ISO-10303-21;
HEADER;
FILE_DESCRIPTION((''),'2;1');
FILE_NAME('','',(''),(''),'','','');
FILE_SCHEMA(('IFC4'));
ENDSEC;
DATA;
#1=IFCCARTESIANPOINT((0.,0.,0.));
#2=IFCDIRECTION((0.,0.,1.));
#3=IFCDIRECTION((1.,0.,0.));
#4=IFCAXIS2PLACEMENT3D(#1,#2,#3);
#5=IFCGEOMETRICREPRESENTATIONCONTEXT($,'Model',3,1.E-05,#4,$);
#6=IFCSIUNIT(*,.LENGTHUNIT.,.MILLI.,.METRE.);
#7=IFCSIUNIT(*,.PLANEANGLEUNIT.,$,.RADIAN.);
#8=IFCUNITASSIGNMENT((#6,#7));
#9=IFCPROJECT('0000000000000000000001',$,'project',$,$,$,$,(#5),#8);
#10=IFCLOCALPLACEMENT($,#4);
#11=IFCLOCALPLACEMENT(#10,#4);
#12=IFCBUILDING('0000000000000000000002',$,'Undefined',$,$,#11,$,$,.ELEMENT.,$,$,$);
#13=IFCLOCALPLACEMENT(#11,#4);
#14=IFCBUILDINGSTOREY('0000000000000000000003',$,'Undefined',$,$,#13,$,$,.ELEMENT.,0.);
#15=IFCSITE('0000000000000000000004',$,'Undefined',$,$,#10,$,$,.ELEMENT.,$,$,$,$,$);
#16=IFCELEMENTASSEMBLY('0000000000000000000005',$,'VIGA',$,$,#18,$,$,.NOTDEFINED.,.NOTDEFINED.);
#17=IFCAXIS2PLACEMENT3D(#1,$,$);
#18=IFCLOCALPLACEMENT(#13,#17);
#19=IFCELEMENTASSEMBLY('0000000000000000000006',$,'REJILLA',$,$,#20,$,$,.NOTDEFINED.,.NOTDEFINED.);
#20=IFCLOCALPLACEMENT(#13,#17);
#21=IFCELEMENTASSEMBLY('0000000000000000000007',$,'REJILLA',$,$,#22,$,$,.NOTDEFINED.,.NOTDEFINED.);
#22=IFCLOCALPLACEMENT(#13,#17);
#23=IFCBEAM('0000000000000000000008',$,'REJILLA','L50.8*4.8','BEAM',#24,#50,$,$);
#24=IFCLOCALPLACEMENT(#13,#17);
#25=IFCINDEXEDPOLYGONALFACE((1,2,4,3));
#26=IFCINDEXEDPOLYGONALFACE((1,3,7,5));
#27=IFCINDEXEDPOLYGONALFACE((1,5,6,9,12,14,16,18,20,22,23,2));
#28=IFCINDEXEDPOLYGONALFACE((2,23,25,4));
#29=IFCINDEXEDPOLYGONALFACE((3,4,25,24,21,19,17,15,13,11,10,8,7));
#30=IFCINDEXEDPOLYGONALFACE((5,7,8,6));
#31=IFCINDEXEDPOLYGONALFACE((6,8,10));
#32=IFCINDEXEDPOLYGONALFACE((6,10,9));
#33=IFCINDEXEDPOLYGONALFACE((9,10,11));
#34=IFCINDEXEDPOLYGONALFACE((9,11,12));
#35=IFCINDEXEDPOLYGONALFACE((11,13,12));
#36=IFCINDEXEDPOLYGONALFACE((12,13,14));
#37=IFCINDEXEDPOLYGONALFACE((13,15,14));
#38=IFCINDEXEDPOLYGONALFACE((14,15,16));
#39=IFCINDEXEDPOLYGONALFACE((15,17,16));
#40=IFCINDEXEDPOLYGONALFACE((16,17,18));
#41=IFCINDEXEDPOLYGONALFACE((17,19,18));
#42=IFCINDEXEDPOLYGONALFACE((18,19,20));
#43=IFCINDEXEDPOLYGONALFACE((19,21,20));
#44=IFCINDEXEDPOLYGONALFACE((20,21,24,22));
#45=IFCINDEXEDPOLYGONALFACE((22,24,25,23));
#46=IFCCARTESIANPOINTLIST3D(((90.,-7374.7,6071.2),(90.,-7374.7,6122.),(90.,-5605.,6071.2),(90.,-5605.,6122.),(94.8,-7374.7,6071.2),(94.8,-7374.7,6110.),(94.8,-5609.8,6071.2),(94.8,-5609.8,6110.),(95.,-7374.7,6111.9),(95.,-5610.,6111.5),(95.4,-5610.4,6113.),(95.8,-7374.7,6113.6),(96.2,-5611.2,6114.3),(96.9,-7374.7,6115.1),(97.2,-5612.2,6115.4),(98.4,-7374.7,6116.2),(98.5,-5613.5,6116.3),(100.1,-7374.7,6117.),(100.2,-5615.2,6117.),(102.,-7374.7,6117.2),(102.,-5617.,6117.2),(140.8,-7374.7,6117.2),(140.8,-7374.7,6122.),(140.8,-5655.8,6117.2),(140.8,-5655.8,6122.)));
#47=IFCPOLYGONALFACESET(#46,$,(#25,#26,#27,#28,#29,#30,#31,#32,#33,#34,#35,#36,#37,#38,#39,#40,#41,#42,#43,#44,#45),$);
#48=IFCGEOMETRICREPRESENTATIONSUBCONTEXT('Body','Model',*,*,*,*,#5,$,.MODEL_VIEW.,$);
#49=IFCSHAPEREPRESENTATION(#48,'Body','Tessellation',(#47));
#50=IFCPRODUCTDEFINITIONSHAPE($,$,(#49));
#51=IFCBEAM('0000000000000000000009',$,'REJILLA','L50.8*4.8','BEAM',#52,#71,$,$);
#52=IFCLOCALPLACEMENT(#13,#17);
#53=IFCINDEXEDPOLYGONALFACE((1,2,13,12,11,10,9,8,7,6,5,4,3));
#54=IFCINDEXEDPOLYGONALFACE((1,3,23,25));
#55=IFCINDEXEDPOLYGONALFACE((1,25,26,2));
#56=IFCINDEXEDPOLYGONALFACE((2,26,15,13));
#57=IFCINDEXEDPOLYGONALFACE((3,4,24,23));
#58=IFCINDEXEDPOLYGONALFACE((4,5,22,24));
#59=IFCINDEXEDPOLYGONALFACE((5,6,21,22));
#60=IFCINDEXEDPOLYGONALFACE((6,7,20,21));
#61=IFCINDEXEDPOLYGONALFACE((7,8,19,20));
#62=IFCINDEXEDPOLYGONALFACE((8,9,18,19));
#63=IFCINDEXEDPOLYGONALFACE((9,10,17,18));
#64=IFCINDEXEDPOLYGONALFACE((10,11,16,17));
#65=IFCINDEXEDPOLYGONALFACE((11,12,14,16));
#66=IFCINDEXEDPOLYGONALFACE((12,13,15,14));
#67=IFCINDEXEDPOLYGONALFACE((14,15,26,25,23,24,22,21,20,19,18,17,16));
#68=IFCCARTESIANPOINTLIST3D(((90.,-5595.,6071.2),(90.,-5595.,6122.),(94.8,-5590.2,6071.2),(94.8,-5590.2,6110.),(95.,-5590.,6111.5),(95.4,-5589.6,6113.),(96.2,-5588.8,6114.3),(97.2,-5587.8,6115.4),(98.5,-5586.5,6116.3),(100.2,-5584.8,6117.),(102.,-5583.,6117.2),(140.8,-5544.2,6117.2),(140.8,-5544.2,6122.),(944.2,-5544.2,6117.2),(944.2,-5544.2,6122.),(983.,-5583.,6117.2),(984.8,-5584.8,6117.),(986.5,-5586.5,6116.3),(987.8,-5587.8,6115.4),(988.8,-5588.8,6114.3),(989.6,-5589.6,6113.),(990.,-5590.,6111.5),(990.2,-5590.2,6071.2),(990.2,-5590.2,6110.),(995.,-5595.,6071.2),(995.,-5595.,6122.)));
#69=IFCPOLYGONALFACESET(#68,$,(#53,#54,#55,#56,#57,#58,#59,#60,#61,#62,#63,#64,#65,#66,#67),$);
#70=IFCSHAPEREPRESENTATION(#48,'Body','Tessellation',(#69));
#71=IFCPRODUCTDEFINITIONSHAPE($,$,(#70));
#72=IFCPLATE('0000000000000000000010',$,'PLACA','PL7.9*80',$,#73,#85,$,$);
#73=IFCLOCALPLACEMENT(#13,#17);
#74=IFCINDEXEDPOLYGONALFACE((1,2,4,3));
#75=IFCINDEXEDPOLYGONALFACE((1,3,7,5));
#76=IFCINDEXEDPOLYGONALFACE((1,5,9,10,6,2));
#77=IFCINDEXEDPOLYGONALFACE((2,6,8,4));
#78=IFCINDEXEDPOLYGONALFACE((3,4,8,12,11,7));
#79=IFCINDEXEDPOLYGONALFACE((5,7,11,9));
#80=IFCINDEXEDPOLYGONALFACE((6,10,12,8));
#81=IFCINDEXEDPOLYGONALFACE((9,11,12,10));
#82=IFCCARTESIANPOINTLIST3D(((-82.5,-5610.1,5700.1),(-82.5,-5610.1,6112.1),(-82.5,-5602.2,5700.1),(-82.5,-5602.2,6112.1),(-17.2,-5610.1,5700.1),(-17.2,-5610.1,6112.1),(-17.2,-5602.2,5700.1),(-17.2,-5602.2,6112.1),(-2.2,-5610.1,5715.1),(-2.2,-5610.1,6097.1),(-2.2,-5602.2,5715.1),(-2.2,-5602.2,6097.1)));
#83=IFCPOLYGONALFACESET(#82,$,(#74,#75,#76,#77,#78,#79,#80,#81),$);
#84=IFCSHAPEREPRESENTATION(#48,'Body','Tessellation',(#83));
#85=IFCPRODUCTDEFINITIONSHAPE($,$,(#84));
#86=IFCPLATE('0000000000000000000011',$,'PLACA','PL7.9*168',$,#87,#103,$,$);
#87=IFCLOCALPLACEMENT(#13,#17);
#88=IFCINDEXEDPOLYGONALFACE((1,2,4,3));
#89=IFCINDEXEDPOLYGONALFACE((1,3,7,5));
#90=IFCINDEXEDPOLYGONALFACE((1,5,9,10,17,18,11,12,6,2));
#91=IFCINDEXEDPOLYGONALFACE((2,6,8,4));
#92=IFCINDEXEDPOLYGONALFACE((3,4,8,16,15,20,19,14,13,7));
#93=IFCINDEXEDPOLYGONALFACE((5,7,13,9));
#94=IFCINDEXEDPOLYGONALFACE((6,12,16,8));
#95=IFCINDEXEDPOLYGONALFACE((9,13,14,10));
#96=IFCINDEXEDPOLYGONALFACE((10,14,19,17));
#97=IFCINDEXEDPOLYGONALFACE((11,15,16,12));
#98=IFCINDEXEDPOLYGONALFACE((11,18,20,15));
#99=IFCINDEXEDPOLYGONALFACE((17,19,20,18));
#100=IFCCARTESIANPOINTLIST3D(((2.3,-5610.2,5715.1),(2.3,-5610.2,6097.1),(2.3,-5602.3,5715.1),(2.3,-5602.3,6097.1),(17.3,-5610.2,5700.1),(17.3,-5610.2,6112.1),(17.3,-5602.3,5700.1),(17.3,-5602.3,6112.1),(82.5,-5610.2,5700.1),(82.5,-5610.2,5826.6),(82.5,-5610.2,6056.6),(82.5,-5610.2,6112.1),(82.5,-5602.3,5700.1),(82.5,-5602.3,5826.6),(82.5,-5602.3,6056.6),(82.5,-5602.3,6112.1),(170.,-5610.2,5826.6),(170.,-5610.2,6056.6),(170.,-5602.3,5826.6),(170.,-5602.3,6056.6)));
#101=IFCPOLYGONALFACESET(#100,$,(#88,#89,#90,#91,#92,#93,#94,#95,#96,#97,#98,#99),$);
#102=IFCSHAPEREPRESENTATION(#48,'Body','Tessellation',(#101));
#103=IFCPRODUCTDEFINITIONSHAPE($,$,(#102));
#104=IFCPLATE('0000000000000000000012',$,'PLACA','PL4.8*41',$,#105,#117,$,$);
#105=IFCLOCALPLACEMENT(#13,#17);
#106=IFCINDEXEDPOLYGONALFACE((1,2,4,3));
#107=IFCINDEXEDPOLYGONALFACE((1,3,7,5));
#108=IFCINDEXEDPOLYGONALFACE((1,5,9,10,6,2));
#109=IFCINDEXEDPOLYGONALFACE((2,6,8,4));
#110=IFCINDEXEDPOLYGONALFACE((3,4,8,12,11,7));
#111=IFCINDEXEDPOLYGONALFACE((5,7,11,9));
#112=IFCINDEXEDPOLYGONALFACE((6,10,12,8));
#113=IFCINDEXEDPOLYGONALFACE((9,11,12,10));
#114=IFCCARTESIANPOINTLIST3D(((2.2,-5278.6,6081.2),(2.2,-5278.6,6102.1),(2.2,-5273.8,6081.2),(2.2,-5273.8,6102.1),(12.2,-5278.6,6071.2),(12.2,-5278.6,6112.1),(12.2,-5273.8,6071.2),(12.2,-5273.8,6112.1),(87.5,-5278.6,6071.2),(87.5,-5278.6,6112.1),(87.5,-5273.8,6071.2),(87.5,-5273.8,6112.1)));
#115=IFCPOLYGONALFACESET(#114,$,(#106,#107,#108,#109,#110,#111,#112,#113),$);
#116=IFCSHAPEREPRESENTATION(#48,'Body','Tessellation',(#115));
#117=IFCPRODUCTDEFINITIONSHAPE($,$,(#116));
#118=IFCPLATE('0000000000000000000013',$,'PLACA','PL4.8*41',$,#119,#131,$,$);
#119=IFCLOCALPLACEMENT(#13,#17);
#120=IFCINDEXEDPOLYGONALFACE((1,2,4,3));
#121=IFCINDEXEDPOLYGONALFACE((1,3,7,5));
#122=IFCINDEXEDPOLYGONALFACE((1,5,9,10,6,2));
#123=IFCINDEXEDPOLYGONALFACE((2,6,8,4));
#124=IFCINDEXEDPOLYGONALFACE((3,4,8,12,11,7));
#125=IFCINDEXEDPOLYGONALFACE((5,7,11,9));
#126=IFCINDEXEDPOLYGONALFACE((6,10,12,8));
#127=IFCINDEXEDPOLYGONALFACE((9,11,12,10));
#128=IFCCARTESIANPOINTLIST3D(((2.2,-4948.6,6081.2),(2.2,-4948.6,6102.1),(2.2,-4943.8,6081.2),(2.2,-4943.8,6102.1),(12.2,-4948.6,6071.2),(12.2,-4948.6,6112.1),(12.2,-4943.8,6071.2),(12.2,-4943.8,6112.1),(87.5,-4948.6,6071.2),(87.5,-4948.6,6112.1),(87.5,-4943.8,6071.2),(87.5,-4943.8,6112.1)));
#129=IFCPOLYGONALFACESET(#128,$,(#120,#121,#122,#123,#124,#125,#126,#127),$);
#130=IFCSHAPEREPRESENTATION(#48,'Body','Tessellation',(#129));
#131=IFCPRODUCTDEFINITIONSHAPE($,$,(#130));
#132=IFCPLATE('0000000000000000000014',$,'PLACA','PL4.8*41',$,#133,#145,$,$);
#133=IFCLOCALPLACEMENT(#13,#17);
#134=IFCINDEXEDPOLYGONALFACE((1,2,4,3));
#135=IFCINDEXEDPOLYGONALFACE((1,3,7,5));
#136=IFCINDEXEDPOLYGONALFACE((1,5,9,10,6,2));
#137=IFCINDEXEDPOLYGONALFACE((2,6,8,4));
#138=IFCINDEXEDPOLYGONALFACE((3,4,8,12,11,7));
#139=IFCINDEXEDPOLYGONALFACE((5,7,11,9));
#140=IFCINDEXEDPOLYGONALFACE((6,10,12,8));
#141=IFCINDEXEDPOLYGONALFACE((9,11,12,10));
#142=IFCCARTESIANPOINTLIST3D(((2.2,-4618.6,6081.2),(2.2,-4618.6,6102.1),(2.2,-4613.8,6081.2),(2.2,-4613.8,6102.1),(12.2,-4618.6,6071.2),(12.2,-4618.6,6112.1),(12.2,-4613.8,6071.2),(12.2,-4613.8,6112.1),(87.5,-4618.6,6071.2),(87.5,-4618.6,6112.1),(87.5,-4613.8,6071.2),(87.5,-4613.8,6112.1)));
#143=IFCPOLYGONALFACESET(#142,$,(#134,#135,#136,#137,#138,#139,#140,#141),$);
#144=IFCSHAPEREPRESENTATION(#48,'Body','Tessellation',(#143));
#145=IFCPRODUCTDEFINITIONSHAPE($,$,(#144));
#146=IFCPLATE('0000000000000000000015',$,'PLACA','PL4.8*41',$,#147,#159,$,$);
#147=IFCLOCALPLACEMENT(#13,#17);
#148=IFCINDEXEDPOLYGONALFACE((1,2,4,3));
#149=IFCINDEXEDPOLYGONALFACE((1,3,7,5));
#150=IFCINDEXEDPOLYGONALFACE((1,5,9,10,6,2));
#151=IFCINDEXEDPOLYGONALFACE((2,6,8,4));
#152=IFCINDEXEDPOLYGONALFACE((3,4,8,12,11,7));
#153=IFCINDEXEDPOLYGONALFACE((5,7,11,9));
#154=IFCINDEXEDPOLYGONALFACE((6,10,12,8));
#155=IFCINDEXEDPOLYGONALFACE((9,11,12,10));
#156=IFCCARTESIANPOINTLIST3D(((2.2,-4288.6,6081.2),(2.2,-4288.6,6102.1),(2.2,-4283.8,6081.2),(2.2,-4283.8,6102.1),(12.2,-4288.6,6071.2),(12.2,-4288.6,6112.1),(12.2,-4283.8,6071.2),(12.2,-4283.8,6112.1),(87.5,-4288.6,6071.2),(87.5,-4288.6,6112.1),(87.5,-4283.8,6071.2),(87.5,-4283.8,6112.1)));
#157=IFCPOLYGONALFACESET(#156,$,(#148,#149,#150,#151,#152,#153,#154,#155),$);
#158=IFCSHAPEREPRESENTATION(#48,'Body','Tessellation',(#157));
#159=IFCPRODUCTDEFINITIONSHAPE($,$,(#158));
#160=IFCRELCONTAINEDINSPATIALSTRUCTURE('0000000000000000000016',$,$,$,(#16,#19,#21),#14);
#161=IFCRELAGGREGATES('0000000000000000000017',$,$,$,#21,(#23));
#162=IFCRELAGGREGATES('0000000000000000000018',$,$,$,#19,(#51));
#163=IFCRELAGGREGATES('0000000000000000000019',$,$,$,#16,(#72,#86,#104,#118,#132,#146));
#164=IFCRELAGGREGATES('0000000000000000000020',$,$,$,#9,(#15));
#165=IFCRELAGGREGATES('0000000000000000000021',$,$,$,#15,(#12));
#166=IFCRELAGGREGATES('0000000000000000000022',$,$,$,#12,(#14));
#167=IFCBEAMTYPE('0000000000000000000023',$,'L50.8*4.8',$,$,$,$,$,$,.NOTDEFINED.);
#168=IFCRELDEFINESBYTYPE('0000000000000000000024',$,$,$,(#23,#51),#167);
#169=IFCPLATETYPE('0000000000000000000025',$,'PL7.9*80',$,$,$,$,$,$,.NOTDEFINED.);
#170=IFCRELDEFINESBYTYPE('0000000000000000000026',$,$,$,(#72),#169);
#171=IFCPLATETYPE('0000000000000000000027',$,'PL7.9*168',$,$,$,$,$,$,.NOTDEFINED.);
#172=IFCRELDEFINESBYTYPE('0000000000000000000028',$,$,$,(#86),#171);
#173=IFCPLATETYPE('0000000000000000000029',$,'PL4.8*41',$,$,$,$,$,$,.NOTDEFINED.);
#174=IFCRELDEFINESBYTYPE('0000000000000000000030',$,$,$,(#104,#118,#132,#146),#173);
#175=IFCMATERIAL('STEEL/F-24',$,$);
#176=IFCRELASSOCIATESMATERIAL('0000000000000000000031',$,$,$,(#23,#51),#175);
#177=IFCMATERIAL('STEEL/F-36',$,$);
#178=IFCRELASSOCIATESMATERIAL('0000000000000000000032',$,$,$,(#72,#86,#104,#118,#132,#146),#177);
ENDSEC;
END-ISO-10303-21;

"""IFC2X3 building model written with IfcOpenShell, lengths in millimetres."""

from ifc_helpers import new_model, si_unit, frame, origin_with_axes, origin_2d_with_axis, place, context, subcontext, project, spatial, polyline, l_section, outline, extrude, clip, halfspace, material, type_object, element, aggregate, save


model = new_model("IFC2X3")

# Units and contexts
model_context = context("Model", 3, precision=1e-05, world=origin_with_axes())
body_context = subcontext(model_context, "Body", "Model", "MODEL_VIEW")
ifc_project = project(units=[si_unit("LENGTHUNIT", "METRE", prefix="MILLI"), si_unit("PLANEANGLEUNIT", "RADIAN")], contexts=[model_context])

# Site, building, storey
site_placement = place(None, origin_with_axes())
site = spatial("IfcSite", under=ifc_project, at=site_placement, Name="Undefined", CompositionType="ELEMENT")
building_placement = place(site_placement, origin_with_axes())
building = spatial("IfcBuilding", under=site, at=building_placement, Name="Undefined", CompositionType="ELEMENT")
storey_placement = place(building_placement, origin_with_axes())
storey = spatial("IfcBuildingStorey", under=building, at=storey_placement, Name="Undefined", CompositionType="ELEMENT", Elevation=0.0)

# Element assembly
assembly_1_placement = place(storey_placement, origin_with_axes())
assembly_1 = element("IfcElementAssembly", 1, at=assembly_1_placement, inside=storey, Name="VIGA", AssemblyPlace="NOTDEFINED", PredefinedType="NOTDEFINED")
ifc_material_1 = material(Name="STEEL/F-24")

# Element assemblies, beam
assembly_2_placement = place(storey_placement, origin_with_axes())
assembly_2 = element("IfcElementAssembly", 2, at=assembly_2_placement, inside=storey, Name="REJILLA", AssemblyPlace="NOTDEFINED", PredefinedType="NOTDEFINED")
assembly_3_placement = place(storey_placement, origin_with_axes())
assembly_3 = element("IfcElementAssembly", 3, at=assembly_3_placement, inside=storey, Name="REJILLA", AssemblyPlace="NOTDEFINED", PredefinedType="NOTDEFINED")
beam_type_1 = type_object("IfcBeamType", Name="L50.8*4.8", PredefinedType="NOTDEFINED")
beam_1_placement = place(assembly_3_placement, frame((115.4, -5605.0, 6096.6), z_axis=(0.0, 0.0, -1.0), x_axis=(0.0, -1.0, 0.0)))
beam_1 = element("IfcBeam", 4, at=beam_1_placement, type_object=beam_type_1, material=ifc_material_1, Name="REJILLA", Description="L50.8*4.8", ObjectType="BEAM", context=body_context, shape_type="Clipping", body=[
    clip(extrude(l_section(Depth=50.8, Width=50.8, Thickness=4.8, FilletRadius=7.2, at=origin_2d_with_axis()), frame((1769.7, 0.0, 0.0), z_axis=(-1.0, 0.0, 0.0), x_axis=(0.0, -1.0, 0.0)), (0.0, 0.0, 1.0), 1800.5), halfspace(frame((50.8, -25.4, 0.0), z_axis=(-0.707107, -0.707107, 0.0), x_axis=(0.0, 0.0, -1.0)), False)),
])
aggregate(assembly_3, [beam_1])

# Beam
beam_2_placement = place(assembly_2_placement, frame((90.0, -5569.6, 6096.6), z_axis=(0.0, 0.0, -1.0), x_axis=(1.0, 0.0, 0.0)))
beam_2 = element("IfcBeam", 5, at=beam_2_placement, type_object=beam_type_1, material=ifc_material_1, Name="REJILLA", Description="L50.8*4.8", ObjectType="BEAM", context=body_context, shape_type="Clipping", body=[
    clip(clip(extrude(l_section(Depth=50.8, Width=50.8, Thickness=4.8, FilletRadius=7.2, at=origin_2d_with_axis()), frame((930.9, 0.0, 0.0), z_axis=(-1.0, 0.0, 0.0), x_axis=(0.0, -1.0, 0.0)), (0.0, 0.0, 1.0), 956.8), halfspace(frame((854.2, -25.4, 0.0), z_axis=(-0.707107, 0.707107, 0.0), x_axis=(0.0, 0.0, -1.0)), True)), halfspace(frame((50.8, -25.4, 0.0), z_axis=(-0.707107, -0.707107, 0.0), x_axis=(0.0, 0.0, -1.0)), False)),
])
aggregate(assembly_2, [beam_2])

# Plates
ifc_material_2 = material(Name="STEEL/F-36")
plate_type_1 = type_object("IfcPlateType", Name="PL7.9*80", PredefinedType="NOTDEFINED")
plate_1_placement = place(assembly_1_placement, frame((-2.2, -5606.2, 6112.1), z_axis=(0.0, -1.0, 0.0), x_axis=(-1.0, 0.0, -0.000007)))
plate_1 = element("IfcPlate", 6, at=plate_1_placement, type_object=plate_type_1, material=ifc_material_2, Name="PLACA", Description="PL7.9*80", context=body_context, shape_type="SweptSolid", body=[
    extrude(outline(polyline([(0.0, 15.0), (15.0, 0.0), (80.2, 0.0), (80.3, 412.0), (15.0, 412.0), (0.0, 397.0), (0.0, 15.0)])), frame((0.0, 0.0, -4.0), z_axis=(0.0, 0.0, 1.0), x_axis=(1.0, 0.0, 0.0)), (0.0, 0.0, 1.0), 7.9),
])
plate_type_2 = type_object("IfcPlateType", Name="PL7.9*168", PredefinedType="NOTDEFINED")
plate_2_placement = place(assembly_1_placement, frame((2.3, -5606.2, 6112.1), z_axis=(0.0, 1.0, 0.0), x_axis=(1.0, 0.0, -0.000007)))
plate_2 = element("IfcPlate", 7, at=plate_2_placement, type_object=plate_type_2, material=ifc_material_2, Name="PLACA", Description="PL7.9*168", context=body_context, shape_type="SweptSolid", body=[
    extrude(outline(polyline([(0.0, 15.0), (15.0, 0.0), (80.2, 0.0), (80.3, 55.5), (167.8, 55.5), (167.8, 285.5), (80.3, 285.5), (80.3, 412.0), (15.0, 412.0), (0.0, 397.0), (0.0, 15.0)])), frame((0.0, 0.0, -4.0), z_axis=(0.0, 0.0, 1.0), x_axis=(1.0, 0.0, 0.0)), (0.0, 0.0, 1.0), 7.9),
])
plate_type_3 = type_object("IfcPlateType", Name="PL4.8*41", PredefinedType="NOTDEFINED")
plate_3_placement = place(assembly_1_placement, frame((2.2, -5276.2, 6112.1), z_axis=(0.0, 1.0, 0.0), x_axis=(1.0, 0.0, -0.000007)))
plate_3 = element("IfcPlate", 8, at=plate_3_placement, type_object=plate_type_3, material=ifc_material_2, Name="PLACA", Description="PL4.8*41", context=body_context, shape_type="SweptSolid", body=[
    extrude(outline(polyline([(0.0, 10.0), (10.0, 0.0), (85.2, 0.0), (85.3, 40.9), (10.0, 40.9), (0.0, 30.9), (0.0, 10.0)])), frame((0.0, 0.0, -2.4), z_axis=(0.0, 0.0, 1.0), x_axis=(1.0, 0.0, 0.0)), (0.0, 0.0, 1.0), 4.8),
])
plate_4_placement = place(assembly_1_placement, frame((2.2, -4946.2, 6112.1), z_axis=(0.0, 1.0, 0.0), x_axis=(1.0, 0.0, -0.000007)))
plate_4 = element("IfcPlate", 9, at=plate_4_placement, type_object=plate_type_3, material=ifc_material_2, Name="PLACA", Description="PL4.8*41", context=body_context, shape_type="SweptSolid", body=[
    extrude(outline(polyline([(0.0, 10.0), (10.0, 0.0), (85.2, 0.0), (85.3, 40.9), (10.0, 40.9), (0.0, 30.9), (0.0, 10.0)])), frame((0.0, 0.0, -2.4), z_axis=(0.0, 0.0, 1.0), x_axis=(1.0, 0.0, 0.0)), (0.0, 0.0, 1.0), 4.8),
])
plate_5_placement = place(assembly_1_placement, frame((2.2, -4616.2, 6112.1), z_axis=(0.0, 1.0, 0.0), x_axis=(1.0, 0.0, -0.000007)))
plate_5 = element("IfcPlate", 10, at=plate_5_placement, type_object=plate_type_3, material=ifc_material_2, Name="PLACA", Description="PL4.8*41", context=body_context, shape_type="SweptSolid", body=[
    extrude(outline(polyline([(0.0, 10.0), (10.0, 0.0), (85.2, 0.0), (85.3, 40.9), (10.0, 40.9), (0.0, 30.9), (0.0, 10.0)])), frame((0.0, 0.0, -2.4), z_axis=(0.0, 0.0, 1.0), x_axis=(1.0, 0.0, 0.0)), (0.0, 0.0, 1.0), 4.8),
])
plate_6_placement = place(assembly_1_placement, frame((2.2, -4286.2, 6112.1), z_axis=(0.0, 1.0, 0.0), x_axis=(1.0, 0.0, -0.000007)))
plate_6 = element("IfcPlate", 11, at=plate_6_placement, type_object=plate_type_3, material=ifc_material_2, Name="PLACA", Description="PL4.8*41", context=body_context, shape_type="SweptSolid", body=[
    extrude(outline(polyline([(0.0, 10.0), (10.0, 0.0), (85.2, 0.0), (85.3, 40.9), (10.0, 40.9), (0.0, 30.9), (0.0, 10.0)])), frame((0.0, 0.0, -2.4), z_axis=(0.0, 0.0, 1.0), x_axis=(1.0, 0.0, 0.0)), (0.0, 0.0, 1.0), 4.8),
])

aggregate(assembly_1, [plate_1, plate_2, plate_3, plate_4, plate_5, plate_6])

save(model, "model.ifc")
